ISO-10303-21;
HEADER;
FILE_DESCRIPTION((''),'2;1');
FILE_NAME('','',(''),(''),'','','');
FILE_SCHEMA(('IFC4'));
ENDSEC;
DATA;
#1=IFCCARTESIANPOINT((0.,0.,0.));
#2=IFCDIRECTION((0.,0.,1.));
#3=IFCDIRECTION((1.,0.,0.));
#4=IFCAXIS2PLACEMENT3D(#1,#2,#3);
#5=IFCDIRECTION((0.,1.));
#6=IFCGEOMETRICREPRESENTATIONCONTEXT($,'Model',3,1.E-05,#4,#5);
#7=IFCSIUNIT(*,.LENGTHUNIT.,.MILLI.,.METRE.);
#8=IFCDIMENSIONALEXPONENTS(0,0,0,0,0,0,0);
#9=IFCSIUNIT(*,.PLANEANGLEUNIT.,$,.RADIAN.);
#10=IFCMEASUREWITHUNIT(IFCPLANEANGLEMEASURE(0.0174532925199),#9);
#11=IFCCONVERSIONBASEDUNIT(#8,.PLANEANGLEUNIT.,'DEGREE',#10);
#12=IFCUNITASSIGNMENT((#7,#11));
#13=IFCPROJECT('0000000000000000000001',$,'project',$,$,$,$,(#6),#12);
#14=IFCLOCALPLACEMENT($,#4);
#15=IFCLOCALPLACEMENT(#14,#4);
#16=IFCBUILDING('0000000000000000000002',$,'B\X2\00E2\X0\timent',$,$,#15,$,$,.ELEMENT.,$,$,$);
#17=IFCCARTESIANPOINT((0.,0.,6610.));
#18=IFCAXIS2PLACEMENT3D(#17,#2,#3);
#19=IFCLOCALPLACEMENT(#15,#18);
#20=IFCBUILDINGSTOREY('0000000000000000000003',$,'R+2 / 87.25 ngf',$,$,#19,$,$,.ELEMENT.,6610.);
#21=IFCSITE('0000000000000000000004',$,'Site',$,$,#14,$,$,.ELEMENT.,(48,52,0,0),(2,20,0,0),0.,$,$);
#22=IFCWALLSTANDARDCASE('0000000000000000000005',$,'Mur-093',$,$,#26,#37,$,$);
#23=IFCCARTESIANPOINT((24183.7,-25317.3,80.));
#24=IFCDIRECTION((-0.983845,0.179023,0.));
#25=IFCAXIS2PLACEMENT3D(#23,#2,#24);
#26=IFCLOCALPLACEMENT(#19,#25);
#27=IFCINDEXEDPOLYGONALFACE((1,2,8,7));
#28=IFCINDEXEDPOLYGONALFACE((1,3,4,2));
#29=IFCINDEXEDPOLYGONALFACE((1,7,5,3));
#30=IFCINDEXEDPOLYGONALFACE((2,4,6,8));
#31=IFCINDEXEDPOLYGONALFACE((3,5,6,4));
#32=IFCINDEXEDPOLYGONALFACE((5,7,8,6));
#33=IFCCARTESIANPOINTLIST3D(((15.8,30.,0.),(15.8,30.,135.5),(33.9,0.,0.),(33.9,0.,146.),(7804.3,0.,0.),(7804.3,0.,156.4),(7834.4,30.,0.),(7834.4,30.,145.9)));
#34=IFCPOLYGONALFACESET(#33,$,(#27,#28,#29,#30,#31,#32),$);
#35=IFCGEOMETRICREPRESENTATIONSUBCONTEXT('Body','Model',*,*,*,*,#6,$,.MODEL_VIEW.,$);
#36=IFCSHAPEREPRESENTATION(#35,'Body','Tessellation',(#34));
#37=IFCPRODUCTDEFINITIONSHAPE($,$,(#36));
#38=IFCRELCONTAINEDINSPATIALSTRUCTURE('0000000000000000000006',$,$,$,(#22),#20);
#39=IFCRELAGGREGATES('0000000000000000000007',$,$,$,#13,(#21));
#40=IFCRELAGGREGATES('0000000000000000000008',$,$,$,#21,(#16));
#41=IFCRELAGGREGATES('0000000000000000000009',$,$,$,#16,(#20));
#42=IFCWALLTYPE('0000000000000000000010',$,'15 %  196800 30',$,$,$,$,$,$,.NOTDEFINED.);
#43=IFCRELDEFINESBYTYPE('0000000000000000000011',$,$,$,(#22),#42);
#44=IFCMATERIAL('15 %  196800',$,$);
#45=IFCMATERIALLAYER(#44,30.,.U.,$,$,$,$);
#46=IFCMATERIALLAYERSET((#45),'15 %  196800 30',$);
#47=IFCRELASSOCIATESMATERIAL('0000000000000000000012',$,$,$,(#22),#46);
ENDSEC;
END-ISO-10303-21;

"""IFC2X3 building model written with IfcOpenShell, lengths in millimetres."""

from ifc_helpers import new_model, entity, si_unit, converted_unit, direction, frame, origin_with_axes, place, context, subcontext, project, spatial, polyline, outline, extrude, clip, halfspace, material, layer, layer_set, layer_usage, type_object, element, save


model = new_model("IFC2X3")

# Units and contexts
model_context = context("Model", 3, precision=1e-05, world=origin_with_axes(), true_north=direction((0.0, 1.0)))
body_context = subcontext(model_context, "Body", "Model", "MODEL_VIEW")
ifc_project = project(units=[si_unit("LENGTHUNIT", "METRE", prefix="MILLI"), converted_unit("PLANEANGLEUNIT", "DEGREE", entity("IfcPlaneAngleMeasure", 0.0174532925199), si_unit("PLANEANGLEUNIT", "RADIAN"), dimensions=[0, 0, 0, 0, 0, 0, 0])], contexts=[model_context])

# Site, building, storey
site_placement = place(None, origin_with_axes())
site = spatial("IfcSite", under=ifc_project, at=site_placement, Name="Site", CompositionType="ELEMENT", RefLatitude=(48, 52, 0, 0), RefLongitude=(2, 20, 0, 0), RefElevation=0.0)
building_placement = place(site_placement, origin_with_axes())
building = spatial("IfcBuilding", under=site, at=building_placement, Name="Bâtiment", CompositionType="ELEMENT")
storey_placement = place(building_placement, frame((0.0, 0.0, 6610.0), z_axis=(0.0, 0.0, 1.0), x_axis=(1.0, 0.0, 0.0)))
storey = spatial("IfcBuildingStorey", under=building, at=storey_placement, Name="R+2 / 87.25 ngf", CompositionType="ELEMENT", Elevation=6610.0)

# Shared definitions
ifc_material_1 = material(Name="15 %  196800")

# Wall
ifc_layer_1 = layer(ifc_material_1, 30.0, ventilated="UNKNOWN")
ifc_layer_set_1 = layer_set([ifc_layer_1], Name="15 %  196800 30")
wall_type_1 = type_object("IfcWallType", Name="15 %  196800 30", PredefinedType="NOTDEFINED")
ifc_layer_usage_1 = layer_usage(ifc_layer_set_1, "AXIS2", "NEGATIVE", 30.0)
wall_1_placement = place(storey_placement, frame((24183.7, -25317.3, 80.0), z_axis=(0.0, 0.0, 1.0), x_axis=(-0.983845, 0.179023, 0.0)))
element("IfcWallStandardCase", 1, at=wall_1_placement, inside=storey, type_object=wall_type_1, material=ifc_layer_usage_1, Name="Mur-093", context=body_context, shape_type="Clipping", body=[
    clip(extrude(outline(polyline([(33.9, 0.0), (7804.3, 0.0), (7834.4, 30.0), (15.8, 30.0), (33.9, 0.0)])), origin_with_axes(), (0.0, 0.0, 1.0), 590.0), halfspace(frame((-0.2, 45.5, 130.0), z_axis=(0.001262, -0.330348, -0.943858), x_axis=(0.0, 0.943859, -0.330348)), True)),
])

save(model, "model.ifc")
